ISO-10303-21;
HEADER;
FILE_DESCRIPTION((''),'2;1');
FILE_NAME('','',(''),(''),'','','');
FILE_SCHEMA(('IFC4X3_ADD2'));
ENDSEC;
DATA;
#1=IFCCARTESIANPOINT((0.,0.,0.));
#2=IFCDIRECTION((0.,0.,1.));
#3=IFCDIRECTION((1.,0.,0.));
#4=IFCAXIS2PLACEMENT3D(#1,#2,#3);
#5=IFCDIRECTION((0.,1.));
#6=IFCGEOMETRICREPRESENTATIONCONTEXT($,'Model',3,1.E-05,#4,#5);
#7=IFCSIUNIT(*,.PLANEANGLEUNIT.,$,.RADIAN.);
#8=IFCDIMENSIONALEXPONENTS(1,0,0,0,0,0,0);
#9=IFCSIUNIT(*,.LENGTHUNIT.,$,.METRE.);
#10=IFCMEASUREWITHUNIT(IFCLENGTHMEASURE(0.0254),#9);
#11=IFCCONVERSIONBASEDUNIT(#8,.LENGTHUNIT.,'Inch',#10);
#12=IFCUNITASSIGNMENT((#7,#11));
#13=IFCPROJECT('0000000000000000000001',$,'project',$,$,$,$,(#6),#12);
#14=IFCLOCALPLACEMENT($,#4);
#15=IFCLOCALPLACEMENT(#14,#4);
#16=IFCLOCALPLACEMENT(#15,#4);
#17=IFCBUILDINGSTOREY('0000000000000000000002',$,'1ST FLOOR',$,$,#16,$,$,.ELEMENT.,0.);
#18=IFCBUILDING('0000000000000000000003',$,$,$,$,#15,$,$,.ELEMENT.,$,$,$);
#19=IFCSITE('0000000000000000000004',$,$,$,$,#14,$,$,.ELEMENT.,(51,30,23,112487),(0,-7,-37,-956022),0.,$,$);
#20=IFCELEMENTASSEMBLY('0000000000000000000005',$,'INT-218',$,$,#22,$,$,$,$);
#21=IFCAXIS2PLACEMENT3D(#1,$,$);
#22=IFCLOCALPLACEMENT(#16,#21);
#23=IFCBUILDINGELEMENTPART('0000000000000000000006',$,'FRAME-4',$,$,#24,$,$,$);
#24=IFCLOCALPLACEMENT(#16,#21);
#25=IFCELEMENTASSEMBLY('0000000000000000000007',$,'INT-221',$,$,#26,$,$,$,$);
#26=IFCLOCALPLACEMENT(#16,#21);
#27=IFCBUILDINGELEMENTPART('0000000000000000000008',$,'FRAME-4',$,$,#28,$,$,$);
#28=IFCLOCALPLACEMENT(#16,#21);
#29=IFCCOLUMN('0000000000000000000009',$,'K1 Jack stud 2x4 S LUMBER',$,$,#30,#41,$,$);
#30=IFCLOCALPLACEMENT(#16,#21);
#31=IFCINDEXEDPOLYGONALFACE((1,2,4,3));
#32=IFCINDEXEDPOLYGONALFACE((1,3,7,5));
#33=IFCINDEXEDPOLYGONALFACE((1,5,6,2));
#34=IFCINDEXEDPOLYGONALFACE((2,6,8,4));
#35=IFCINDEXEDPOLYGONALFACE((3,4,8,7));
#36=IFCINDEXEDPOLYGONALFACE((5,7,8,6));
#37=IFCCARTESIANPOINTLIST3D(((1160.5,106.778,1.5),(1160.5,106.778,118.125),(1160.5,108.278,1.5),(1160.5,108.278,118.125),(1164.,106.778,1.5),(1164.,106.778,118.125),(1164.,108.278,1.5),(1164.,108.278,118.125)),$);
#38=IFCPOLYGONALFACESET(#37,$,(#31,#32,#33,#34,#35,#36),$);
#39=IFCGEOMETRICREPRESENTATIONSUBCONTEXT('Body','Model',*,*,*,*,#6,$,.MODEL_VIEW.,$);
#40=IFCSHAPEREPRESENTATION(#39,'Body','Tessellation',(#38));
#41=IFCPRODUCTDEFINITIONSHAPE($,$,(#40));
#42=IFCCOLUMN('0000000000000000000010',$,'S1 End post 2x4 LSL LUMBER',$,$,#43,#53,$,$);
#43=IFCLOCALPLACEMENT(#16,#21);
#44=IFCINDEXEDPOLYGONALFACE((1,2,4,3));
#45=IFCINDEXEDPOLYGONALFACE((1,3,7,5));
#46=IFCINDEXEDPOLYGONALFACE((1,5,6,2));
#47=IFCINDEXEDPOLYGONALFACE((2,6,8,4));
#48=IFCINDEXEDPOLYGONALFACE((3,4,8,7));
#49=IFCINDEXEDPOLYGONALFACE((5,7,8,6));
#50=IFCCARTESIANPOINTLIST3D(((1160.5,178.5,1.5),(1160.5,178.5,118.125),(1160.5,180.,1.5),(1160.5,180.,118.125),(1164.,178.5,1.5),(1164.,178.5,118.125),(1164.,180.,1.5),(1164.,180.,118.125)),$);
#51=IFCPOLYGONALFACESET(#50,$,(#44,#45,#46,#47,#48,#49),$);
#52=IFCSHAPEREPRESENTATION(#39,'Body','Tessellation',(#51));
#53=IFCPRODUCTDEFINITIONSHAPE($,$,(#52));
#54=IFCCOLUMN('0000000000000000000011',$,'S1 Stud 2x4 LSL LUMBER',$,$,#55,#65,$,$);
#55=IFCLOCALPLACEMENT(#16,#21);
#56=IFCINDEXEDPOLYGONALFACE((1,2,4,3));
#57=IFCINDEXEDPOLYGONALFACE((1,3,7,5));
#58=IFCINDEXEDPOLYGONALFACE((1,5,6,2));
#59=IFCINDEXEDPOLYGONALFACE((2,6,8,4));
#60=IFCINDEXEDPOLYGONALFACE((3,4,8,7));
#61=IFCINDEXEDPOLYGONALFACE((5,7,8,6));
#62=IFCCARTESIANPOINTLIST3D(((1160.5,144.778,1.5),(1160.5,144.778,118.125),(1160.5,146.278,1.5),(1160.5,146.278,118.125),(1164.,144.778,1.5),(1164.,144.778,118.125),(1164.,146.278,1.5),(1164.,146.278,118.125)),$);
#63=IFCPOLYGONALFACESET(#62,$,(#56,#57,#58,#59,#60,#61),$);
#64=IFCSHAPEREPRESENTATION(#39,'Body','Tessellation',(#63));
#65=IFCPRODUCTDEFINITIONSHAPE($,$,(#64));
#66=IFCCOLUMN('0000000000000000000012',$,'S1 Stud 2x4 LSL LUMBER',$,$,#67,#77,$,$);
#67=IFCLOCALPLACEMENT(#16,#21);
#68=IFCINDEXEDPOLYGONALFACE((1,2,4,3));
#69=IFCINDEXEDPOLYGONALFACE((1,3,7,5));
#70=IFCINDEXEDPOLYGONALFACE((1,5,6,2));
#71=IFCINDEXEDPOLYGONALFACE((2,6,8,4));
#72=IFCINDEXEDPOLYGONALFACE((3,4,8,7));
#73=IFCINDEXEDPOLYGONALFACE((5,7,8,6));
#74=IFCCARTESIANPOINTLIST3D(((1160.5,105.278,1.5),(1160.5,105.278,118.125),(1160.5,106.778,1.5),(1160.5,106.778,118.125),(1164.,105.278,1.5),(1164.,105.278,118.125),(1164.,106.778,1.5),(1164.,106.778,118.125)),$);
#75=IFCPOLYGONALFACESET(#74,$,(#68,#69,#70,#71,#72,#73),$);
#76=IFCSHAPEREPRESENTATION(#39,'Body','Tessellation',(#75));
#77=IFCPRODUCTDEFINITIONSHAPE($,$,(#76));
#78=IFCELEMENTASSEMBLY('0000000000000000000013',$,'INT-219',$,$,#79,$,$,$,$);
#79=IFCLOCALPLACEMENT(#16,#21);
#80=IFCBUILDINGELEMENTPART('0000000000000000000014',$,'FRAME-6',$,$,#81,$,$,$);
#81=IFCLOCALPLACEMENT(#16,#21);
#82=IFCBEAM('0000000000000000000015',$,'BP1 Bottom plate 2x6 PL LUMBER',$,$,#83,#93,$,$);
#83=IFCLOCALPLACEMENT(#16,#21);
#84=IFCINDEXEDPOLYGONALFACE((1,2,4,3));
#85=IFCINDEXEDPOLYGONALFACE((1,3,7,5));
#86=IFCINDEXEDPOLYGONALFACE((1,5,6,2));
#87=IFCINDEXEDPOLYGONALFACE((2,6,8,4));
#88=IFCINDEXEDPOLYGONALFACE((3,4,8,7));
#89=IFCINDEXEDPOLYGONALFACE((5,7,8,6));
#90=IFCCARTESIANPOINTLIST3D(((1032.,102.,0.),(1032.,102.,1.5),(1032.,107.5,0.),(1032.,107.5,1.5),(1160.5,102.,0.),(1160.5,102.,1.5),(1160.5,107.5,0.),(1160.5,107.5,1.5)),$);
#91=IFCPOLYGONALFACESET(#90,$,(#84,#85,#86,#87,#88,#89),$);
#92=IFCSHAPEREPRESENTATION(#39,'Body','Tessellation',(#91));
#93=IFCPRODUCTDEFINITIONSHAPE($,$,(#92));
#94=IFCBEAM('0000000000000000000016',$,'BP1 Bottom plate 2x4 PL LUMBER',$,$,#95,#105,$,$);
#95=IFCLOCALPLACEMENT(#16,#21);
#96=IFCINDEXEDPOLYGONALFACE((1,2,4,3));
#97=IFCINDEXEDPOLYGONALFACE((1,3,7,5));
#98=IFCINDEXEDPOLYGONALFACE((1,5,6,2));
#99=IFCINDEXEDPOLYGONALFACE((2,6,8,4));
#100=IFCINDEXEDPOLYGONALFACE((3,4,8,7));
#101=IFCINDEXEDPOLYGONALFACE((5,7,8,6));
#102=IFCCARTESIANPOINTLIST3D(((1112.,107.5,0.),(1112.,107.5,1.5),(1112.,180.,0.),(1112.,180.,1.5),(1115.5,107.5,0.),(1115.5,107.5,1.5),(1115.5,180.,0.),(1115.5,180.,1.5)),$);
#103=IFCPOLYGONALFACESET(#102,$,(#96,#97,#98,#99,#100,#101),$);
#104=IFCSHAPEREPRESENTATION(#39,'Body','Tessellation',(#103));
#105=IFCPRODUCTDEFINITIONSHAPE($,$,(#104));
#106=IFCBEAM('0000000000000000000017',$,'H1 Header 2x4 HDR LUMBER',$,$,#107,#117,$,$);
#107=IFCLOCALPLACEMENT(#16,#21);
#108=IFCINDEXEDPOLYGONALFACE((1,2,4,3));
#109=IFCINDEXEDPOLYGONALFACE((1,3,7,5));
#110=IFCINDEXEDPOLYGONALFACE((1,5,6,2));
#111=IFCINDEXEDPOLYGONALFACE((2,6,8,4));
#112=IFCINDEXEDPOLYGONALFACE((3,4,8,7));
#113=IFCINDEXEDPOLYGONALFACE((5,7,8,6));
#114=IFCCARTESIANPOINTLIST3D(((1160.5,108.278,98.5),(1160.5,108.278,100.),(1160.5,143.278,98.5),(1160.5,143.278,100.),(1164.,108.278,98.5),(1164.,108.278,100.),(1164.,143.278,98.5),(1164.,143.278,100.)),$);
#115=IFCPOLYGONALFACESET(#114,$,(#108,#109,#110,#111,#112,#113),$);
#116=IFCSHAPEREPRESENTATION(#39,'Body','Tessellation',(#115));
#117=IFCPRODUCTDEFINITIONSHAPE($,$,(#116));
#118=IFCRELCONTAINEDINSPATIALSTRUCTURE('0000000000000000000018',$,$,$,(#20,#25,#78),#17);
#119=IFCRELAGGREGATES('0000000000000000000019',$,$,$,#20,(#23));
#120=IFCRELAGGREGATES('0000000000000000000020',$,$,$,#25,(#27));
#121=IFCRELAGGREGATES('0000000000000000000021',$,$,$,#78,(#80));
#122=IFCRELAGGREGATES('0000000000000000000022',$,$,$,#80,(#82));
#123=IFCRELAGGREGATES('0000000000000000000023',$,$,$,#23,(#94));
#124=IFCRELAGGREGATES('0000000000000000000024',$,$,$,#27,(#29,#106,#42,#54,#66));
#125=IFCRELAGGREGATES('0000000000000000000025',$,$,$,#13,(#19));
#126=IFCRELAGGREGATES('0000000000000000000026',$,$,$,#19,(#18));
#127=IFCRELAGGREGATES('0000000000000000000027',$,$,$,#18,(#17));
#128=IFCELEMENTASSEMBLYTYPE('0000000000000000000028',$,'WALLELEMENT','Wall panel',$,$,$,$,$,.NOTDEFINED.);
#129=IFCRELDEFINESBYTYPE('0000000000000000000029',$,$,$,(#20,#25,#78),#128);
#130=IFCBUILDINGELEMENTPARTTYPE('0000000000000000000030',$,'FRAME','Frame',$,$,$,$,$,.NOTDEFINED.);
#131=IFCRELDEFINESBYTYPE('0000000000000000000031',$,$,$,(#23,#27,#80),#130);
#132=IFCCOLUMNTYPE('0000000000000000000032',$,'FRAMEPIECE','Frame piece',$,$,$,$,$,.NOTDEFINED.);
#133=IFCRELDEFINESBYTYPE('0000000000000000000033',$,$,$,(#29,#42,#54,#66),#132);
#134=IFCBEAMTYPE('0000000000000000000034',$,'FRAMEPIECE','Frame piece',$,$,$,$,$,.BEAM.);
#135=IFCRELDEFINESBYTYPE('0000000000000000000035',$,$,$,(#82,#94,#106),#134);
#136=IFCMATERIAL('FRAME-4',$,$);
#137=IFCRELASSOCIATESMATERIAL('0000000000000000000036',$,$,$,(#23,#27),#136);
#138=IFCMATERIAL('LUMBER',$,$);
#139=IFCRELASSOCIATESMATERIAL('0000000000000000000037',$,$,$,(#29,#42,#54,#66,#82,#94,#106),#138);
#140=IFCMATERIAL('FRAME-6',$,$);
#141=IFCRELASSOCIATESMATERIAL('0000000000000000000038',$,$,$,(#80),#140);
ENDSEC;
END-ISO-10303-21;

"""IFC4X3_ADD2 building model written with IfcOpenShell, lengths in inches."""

from ifc_helpers import new_model, entity, si_unit, converted_unit, direction, frame, origin_with_axes, origin_2d_with_axis, place, context, subcontext, project, spatial, rectangle, extrude, material, type_object, element, aggregate, save


model = new_model("IFC4X3_ADD2")

# Units and contexts
model_context = context("Model", 3, precision=1e-05, world=origin_with_axes(), true_north=direction((0.0, 1.0)))
body_context = subcontext(model_context, "Body", "Model", "MODEL_VIEW")
ifc_project = project(units=[si_unit("PLANEANGLEUNIT", "RADIAN"), converted_unit("LENGTHUNIT", "Inch", entity("IfcLengthMeasure", 0.0254), si_unit("LENGTHUNIT", "METRE"), dimensions=[1, 0, 0, 0, 0, 0, 0])], contexts=[model_context])

# Site, building, storey
site_placement = place(None, origin_with_axes())
site = spatial("IfcSite", under=ifc_project, at=site_placement, CompositionType="ELEMENT", RefLatitude=(51, 30, 23, 112487), RefLongitude=(0, -7, -37, -956022), RefElevation=0.0)
building_placement = place(site_placement, origin_with_axes())
building = spatial("IfcBuilding", under=site, at=building_placement, CompositionType="ELEMENT")
storey_placement = place(building_placement, origin_with_axes())
storey = spatial("IfcBuildingStorey", under=building, at=storey_placement, Name="1ST FLOOR", CompositionType="ELEMENT", Elevation=0.0)

# Element assemblies, building element parts, columns
element_assembly_type = type_object("IfcElementAssemblyType", Name="WALLELEMENT", Description="Wall panel", PredefinedType="NOTDEFINED")
assembly_1_placement = place(storey_placement, origin_with_axes())
assembly_1 = element("IfcElementAssembly", 1, at=assembly_1_placement, inside=storey, type_object=element_assembly_type, Name="INT-218")
ifc_material_1 = material(Name="FRAME-4")
building_element_part_type = type_object("IfcBuildingElementPartType", Name="FRAME", Description="Frame", PredefinedType="NOTDEFINED")
building_element_part_1_placement = place(storey_placement, origin_with_axes())
building_element_part_1 = element("IfcBuildingElementPart", 2, at=building_element_part_1_placement, type_object=building_element_part_type, material=ifc_material_1, Name="FRAME-4")
aggregate(assembly_1, [building_element_part_1])
ifc_material_2 = material(Name="LUMBER")
column_type = type_object("IfcColumnType", Name="FRAMEPIECE", Description="Frame piece", PredefinedType="NOTDEFINED")
assembly_2_placement = place(storey_placement, origin_with_axes())
assembly_2 = element("IfcElementAssembly", 3, at=assembly_2_placement, inside=storey, type_object=element_assembly_type, Name="INT-221")
building_element_part_2_placement = place(storey_placement, origin_with_axes())
building_element_part_2 = element("IfcBuildingElementPart", 4, at=building_element_part_2_placement, type_object=building_element_part_type, material=ifc_material_1, Name="FRAME-4")
aggregate(assembly_2, [building_element_part_2])
column_1_placement = place(storey_placement, frame((1162.25, 107.528, 118.125), z_axis=(0.0, 0.0, -1.0), x_axis=(0.0, 1.0, 0.0)))
column_1 = element("IfcColumn", 5, at=column_1_placement, type_object=column_type, material=ifc_material_2, Name="K1 Jack stud 2x4 S LUMBER", context=body_context, shape_type="SweptSolid", body=[
    extrude(rectangle(XDim=1.5, YDim=3.5, at=origin_2d_with_axis()), origin_with_axes(), (0.0, 0.0, 1.0), 116.625),
])
column_2_placement = place(storey_placement, frame((1162.25, 179.25, 1.5), z_axis=(0.0, 0.0, 1.0), x_axis=(0.0, -1.0, 0.0)))
column_2 = element("IfcColumn", 6, at=column_2_placement, type_object=column_type, material=ifc_material_2, Name="S1 End post 2x4 LSL LUMBER", context=body_context, shape_type="SweptSolid", body=[
    extrude(rectangle(XDim=1.5, YDim=3.5, at=origin_2d_with_axis()), origin_with_axes(), (0.0, 0.0, 1.0), 116.625),
])
column_3_placement = place(storey_placement, frame((1162.25, 145.528, 118.125), z_axis=(0.0, 0.0, -1.0), x_axis=(0.0, 1.0, 0.0)))
column_3 = element("IfcColumn", 7, at=column_3_placement, type_object=column_type, material=ifc_material_2, Name="S1 Stud 2x4 LSL LUMBER", context=body_context, shape_type="SweptSolid", body=[
    extrude(rectangle(XDim=1.5, YDim=3.5, at=origin_2d_with_axis()), origin_with_axes(), (0.0, 0.0, 1.0), 116.625),
])
column_4_placement = place(storey_placement, frame((1162.25, 106.028, 1.5), z_axis=(0.0, 0.0, 1.0), x_axis=(0.0, -1.0, 0.0)))
column_4 = element("IfcColumn", 8, at=column_4_placement, type_object=column_type, material=ifc_material_2, Name="S1 Stud 2x4 LSL LUMBER", context=body_context, shape_type="SweptSolid", body=[
    extrude(rectangle(XDim=1.5, YDim=3.5, at=origin_2d_with_axis()), origin_with_axes(), (0.0, 0.0, 1.0), 116.625),
])

# Element assembly, building element part, beam
assembly_3_placement = place(storey_placement, origin_with_axes())
assembly_3 = element("IfcElementAssembly", 9, at=assembly_3_placement, inside=storey, type_object=element_assembly_type, Name="INT-219")
ifc_material_3 = material(Name="FRAME-6")
building_element_part_3_placement = place(storey_placement, origin_with_axes())
building_element_part_3 = element("IfcBuildingElementPart", 10, at=building_element_part_3_placement, type_object=building_element_part_type, material=ifc_material_3, Name="FRAME-6")
aggregate(assembly_3, [building_element_part_3])
beam_type = type_object("IfcBeamType", Name="FRAMEPIECE", Description="Frame piece", PredefinedType="BEAM")
beam_1_placement = place(storey_placement, frame((1160.5, 104.75, 0.75), z_axis=(-1.0, 0.0, 0.0), x_axis=(0.0, 0.0, 1.0)))
beam_1 = element("IfcBeam", 11, at=beam_1_placement, type_object=beam_type, material=ifc_material_2, Name="BP1 Bottom plate 2x6 PL LUMBER", context=body_context, shape_type="SweptSolid", body=[
    extrude(rectangle(XDim=1.5, YDim=5.5, at=origin_2d_with_axis()), origin_with_axes(), (0.0, 0.0, 1.0), 128.5),
])
aggregate(building_element_part_3, [beam_1])

# Beams
beam_2_placement = place(storey_placement, frame((1113.75, 180.0, 0.75), z_axis=(0.0, -1.0, 0.0), x_axis=(0.0, 0.0, 1.0)))
beam_2 = element("IfcBeam", 12, at=beam_2_placement, type_object=beam_type, material=ifc_material_2, Name="BP1 Bottom plate 2x4 PL LUMBER", context=body_context, shape_type="SweptSolid", body=[
    extrude(rectangle(XDim=1.5, YDim=3.5, at=origin_2d_with_axis()), origin_with_axes(), (0.0, 0.0, 1.0), 72.5),
])
aggregate(building_element_part_1, [beam_2])
beam_3_placement = place(storey_placement, frame((1162.25, 108.278, 99.25), z_axis=(0.0, 1.0, 0.0), x_axis=(0.0, 0.0, 1.0)))
beam_3 = element("IfcBeam", 13, at=beam_3_placement, type_object=beam_type, material=ifc_material_2, Name="H1 Header 2x4 HDR LUMBER", context=body_context, shape_type="SweptSolid", body=[
    extrude(rectangle(XDim=1.5, YDim=3.5, at=origin_2d_with_axis()), origin_with_axes(), (0.0, 0.0, 1.0), 35.0),
])
aggregate(building_element_part_2, [column_1, beam_3, column_2, column_3, column_4])

save(model, "model.ifc")
